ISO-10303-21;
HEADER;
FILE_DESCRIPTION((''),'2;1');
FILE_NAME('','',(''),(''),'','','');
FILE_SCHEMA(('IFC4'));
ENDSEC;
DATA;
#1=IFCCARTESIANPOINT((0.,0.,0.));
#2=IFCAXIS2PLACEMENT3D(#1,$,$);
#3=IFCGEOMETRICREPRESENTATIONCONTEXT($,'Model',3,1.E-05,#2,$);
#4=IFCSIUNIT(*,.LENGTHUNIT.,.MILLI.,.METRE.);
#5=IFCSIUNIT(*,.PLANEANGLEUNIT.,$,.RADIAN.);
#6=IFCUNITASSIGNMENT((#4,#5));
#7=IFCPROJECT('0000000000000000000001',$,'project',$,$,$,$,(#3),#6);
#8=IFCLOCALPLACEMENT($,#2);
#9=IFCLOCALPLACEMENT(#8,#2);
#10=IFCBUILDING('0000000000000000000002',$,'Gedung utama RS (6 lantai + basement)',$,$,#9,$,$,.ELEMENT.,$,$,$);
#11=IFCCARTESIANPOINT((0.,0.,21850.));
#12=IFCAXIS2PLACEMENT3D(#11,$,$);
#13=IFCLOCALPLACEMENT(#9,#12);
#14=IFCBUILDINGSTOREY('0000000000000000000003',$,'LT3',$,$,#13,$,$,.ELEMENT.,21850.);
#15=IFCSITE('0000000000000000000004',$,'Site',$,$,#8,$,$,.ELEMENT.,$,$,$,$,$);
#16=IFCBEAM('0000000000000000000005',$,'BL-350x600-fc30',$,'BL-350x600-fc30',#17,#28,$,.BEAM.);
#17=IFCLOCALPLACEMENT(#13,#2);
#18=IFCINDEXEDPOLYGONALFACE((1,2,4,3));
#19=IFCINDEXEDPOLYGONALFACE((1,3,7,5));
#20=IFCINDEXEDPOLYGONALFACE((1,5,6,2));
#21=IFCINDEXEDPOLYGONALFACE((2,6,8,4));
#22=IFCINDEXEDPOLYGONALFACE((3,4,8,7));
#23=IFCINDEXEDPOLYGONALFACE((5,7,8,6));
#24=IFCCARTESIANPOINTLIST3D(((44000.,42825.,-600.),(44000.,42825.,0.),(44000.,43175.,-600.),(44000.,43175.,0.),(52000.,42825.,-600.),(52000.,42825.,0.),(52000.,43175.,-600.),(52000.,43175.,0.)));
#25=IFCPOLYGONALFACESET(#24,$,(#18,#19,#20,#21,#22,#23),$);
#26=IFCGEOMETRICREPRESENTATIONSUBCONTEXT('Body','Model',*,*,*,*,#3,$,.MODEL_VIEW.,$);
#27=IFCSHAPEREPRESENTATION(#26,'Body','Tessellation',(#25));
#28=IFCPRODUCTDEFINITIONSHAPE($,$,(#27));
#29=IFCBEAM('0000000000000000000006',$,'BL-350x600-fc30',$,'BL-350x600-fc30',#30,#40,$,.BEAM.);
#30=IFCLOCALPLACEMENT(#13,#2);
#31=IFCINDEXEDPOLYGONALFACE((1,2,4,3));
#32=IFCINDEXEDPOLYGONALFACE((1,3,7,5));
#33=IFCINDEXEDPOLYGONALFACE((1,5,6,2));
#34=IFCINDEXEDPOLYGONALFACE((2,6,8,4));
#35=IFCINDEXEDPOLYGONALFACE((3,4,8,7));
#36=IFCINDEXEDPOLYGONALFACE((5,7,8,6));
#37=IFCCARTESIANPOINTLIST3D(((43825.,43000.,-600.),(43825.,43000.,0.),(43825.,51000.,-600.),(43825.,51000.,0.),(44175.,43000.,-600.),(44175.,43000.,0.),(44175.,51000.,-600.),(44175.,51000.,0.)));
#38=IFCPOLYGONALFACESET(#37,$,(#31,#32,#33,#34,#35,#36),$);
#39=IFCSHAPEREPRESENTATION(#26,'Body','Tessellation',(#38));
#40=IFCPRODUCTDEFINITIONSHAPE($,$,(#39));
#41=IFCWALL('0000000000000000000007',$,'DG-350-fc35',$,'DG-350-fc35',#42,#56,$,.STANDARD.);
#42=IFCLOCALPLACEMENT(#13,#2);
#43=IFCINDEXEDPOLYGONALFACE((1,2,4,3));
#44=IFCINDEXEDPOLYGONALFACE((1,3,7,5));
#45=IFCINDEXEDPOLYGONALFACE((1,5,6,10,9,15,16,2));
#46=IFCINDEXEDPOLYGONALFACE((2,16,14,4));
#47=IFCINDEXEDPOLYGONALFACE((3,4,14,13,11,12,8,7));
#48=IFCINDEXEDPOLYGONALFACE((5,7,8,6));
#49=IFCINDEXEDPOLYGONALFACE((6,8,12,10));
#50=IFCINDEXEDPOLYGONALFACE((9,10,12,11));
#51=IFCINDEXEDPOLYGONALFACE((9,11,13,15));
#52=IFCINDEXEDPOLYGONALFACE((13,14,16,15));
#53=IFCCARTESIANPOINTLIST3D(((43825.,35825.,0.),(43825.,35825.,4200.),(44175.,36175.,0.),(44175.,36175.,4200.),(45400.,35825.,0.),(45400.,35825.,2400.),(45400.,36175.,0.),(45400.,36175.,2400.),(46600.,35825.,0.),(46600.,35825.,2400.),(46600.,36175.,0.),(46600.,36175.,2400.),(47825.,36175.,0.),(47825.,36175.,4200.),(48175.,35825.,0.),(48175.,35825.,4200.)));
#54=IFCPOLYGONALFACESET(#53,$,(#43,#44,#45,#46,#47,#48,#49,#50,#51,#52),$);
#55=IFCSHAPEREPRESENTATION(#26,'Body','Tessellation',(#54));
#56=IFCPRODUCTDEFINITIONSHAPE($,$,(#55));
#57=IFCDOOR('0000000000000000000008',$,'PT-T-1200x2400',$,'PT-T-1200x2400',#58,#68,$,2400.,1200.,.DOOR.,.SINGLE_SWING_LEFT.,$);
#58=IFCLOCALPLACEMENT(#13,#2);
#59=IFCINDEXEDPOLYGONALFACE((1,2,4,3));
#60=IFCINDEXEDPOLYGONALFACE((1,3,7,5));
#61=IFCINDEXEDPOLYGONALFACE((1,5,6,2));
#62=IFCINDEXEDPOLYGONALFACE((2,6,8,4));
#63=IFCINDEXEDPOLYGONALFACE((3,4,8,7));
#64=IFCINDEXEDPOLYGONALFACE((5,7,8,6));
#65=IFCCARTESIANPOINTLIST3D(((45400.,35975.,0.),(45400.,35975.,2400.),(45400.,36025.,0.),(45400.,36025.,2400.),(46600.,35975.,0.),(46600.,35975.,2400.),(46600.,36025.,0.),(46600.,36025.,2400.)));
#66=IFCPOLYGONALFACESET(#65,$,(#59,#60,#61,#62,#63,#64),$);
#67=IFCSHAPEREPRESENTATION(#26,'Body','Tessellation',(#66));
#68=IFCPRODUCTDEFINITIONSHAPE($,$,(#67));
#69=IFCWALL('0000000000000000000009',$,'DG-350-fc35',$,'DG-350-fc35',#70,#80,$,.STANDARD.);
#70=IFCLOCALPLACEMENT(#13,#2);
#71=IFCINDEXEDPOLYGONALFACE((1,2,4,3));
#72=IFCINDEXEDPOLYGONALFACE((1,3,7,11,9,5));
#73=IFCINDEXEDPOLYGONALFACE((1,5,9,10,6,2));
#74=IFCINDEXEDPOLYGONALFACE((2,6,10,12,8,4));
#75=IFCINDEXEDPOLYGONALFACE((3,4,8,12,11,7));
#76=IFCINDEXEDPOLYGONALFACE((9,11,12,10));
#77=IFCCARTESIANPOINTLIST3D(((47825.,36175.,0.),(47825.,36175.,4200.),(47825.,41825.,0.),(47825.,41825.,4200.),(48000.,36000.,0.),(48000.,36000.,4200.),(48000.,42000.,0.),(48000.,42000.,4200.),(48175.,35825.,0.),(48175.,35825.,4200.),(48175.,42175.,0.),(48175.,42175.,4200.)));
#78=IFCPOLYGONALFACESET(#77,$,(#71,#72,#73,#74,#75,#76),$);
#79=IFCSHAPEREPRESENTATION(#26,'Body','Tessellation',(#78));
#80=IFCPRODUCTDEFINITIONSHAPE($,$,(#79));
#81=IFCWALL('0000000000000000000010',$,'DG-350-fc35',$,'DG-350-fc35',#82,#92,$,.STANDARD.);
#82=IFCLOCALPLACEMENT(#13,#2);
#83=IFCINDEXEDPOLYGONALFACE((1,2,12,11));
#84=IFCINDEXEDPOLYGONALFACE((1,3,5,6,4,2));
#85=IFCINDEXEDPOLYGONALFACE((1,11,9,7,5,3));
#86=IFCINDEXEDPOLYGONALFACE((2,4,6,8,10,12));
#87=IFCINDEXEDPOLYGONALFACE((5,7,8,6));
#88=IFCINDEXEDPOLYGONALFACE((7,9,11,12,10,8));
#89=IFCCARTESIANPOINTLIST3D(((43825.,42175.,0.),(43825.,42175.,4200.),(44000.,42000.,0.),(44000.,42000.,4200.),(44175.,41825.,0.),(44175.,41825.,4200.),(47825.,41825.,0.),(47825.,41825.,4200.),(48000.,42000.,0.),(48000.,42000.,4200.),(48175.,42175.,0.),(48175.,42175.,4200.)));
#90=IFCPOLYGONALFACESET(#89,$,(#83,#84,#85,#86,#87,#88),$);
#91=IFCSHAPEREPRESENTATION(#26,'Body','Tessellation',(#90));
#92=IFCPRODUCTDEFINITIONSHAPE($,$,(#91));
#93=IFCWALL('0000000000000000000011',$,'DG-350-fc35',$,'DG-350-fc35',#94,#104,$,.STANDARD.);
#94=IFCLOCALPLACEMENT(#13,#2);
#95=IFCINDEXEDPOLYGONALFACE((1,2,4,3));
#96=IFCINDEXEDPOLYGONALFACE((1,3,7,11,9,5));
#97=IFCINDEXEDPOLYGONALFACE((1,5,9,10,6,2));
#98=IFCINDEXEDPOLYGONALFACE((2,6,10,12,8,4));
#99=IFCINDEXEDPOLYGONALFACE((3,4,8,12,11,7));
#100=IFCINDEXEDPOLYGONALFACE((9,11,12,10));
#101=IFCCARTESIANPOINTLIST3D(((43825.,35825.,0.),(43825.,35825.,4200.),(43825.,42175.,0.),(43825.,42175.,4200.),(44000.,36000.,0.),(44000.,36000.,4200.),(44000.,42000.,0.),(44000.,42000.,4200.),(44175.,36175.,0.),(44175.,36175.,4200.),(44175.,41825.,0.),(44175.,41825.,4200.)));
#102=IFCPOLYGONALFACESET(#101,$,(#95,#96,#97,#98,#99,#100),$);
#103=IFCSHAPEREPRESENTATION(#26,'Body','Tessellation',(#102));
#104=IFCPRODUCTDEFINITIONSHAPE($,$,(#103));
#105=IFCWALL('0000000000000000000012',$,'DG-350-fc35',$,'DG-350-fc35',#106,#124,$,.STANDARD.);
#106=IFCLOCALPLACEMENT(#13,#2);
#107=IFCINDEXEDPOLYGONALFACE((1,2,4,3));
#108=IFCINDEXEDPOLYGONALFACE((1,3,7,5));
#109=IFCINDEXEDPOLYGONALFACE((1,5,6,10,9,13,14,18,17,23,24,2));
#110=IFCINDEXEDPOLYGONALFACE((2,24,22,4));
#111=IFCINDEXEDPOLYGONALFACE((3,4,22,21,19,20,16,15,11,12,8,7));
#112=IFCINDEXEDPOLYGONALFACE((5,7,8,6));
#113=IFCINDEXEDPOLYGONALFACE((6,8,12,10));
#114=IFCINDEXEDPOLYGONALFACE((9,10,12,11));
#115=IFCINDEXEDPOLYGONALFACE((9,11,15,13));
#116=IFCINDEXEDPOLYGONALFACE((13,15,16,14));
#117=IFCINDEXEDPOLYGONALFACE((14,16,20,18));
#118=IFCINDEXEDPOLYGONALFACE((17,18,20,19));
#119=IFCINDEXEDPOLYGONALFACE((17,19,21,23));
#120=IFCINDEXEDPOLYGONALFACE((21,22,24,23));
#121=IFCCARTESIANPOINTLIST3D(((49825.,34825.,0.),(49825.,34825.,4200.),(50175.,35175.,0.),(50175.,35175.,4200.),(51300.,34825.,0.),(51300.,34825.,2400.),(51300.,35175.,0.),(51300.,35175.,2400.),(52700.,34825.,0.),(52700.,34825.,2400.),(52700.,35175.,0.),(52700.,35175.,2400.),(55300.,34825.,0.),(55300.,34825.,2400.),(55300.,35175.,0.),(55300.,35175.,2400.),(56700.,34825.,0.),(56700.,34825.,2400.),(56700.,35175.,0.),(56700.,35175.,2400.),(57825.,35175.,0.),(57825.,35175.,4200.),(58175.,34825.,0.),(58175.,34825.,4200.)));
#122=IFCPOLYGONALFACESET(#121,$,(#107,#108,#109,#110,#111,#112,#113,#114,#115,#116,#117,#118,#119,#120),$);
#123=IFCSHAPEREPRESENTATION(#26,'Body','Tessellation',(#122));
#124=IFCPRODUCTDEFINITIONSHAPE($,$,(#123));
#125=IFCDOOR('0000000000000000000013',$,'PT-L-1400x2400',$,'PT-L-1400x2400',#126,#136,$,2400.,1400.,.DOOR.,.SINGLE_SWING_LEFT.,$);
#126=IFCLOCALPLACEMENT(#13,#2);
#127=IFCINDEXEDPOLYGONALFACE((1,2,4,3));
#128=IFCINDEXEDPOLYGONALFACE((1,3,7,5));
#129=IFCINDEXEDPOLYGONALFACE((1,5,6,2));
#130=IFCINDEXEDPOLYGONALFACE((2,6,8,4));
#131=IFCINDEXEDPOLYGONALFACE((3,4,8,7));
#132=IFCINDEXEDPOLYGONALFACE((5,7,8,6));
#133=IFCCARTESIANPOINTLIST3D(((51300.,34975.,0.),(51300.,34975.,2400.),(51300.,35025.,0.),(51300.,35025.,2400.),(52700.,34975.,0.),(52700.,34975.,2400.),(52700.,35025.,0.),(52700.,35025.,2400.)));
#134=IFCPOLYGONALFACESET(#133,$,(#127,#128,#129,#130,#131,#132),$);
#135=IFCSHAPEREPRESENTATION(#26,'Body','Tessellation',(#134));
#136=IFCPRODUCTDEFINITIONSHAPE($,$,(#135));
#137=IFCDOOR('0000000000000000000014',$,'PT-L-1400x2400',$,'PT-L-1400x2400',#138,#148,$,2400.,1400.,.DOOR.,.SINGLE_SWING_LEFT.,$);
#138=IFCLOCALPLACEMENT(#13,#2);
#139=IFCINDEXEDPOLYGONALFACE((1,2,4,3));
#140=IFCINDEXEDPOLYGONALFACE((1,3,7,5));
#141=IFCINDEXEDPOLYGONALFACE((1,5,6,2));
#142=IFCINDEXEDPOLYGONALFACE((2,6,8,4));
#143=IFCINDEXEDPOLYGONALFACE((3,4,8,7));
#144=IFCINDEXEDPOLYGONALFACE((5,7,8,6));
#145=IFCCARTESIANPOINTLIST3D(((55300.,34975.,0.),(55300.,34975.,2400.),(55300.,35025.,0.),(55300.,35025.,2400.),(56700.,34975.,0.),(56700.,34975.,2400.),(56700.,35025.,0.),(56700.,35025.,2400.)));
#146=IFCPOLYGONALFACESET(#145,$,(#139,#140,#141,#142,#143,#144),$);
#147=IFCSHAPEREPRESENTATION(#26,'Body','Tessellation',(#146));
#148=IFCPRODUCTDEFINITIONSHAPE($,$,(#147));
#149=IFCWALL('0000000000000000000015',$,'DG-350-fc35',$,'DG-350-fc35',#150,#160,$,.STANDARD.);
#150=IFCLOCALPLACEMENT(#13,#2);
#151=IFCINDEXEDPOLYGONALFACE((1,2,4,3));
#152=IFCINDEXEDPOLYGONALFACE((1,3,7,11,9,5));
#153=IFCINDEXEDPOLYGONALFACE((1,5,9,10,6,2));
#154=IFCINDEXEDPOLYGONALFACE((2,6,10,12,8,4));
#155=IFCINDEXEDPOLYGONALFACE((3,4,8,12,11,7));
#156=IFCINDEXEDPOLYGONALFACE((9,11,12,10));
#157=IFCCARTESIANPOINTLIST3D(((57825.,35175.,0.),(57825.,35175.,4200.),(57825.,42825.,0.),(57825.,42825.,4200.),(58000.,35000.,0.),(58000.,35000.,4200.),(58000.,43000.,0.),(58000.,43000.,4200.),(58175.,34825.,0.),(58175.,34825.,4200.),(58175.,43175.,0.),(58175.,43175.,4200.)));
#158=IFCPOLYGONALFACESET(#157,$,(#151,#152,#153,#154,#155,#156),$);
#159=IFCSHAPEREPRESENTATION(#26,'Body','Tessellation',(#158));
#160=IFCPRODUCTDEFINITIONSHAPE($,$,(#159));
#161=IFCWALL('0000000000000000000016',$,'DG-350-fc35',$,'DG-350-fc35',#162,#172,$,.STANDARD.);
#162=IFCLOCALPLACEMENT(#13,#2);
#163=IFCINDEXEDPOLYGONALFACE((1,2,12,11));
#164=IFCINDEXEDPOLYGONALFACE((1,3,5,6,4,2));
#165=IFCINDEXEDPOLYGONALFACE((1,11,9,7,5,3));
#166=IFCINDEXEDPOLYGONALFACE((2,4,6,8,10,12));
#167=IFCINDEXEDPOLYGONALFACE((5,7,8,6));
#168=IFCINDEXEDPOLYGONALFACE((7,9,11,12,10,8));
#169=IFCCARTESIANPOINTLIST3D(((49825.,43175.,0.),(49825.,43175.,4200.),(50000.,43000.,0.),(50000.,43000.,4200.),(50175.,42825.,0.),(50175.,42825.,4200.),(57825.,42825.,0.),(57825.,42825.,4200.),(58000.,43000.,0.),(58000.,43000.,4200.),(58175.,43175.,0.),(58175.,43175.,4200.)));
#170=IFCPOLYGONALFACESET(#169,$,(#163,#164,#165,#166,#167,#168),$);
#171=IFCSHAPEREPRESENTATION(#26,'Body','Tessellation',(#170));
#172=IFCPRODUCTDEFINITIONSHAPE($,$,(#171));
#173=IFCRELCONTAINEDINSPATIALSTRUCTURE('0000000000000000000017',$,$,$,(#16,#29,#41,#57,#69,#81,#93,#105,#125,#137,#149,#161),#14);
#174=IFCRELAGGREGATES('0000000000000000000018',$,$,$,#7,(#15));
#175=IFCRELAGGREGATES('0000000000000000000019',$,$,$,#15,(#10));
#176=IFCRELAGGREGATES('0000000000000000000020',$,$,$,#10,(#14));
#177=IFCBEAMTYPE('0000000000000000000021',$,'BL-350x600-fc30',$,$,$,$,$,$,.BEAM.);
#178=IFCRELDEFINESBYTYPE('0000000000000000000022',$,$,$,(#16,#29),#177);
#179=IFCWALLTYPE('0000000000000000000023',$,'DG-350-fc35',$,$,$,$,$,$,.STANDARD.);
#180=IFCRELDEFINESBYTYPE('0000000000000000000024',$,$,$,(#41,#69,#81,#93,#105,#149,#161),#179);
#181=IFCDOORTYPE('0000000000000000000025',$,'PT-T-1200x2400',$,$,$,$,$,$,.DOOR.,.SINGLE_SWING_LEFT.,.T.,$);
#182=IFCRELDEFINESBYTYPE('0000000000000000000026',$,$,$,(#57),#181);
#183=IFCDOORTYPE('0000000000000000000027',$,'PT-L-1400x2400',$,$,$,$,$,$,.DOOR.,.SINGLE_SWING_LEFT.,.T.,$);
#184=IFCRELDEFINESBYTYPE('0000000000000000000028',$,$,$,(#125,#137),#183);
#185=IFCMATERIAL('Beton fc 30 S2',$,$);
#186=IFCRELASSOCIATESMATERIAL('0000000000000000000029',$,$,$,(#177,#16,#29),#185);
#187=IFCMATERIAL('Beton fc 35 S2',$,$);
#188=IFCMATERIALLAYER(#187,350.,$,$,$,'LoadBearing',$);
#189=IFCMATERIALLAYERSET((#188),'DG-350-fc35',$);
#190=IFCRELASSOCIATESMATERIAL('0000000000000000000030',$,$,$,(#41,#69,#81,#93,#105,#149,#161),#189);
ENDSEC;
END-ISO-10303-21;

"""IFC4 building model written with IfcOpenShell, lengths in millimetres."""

from ifc_helpers import new_model, si_unit, frame, frame_2d, origin, origin_2d, place, context, subcontext, project, spatial, polyline, rectangle, outline, extrude, material, layer, layer_set, layer_usage, material_profile, profile_set, profile_usage, type_object, element, fill, save


model = new_model("IFC4")

# Units and contexts
model_context = context("Model", 3, precision=1e-05, world=origin())
body_context = subcontext(model_context, "Body", "Model", "MODEL_VIEW")
ifc_project = project(units=[si_unit("LENGTHUNIT", "METRE", prefix="MILLI"), si_unit("PLANEANGLEUNIT", "RADIAN")], contexts=[model_context])

# Site, building, storey
site_placement = place(None, origin())
site = spatial("IfcSite", under=ifc_project, at=site_placement, Name="Site", CompositionType="ELEMENT")
building_placement = place(site_placement, origin())
building = spatial("IfcBuilding", under=site, at=building_placement, Name="Gedung utama RS (6 lantai + basement)", CompositionType="ELEMENT")
storey_placement = place(building_placement, frame((0.0, 0.0, 21850.0)))
storey = spatial("IfcBuildingStorey", under=building, at=storey_placement, Name="LT3", CompositionType="ELEMENT", Elevation=21850.0)

# Beams
ifc_material_1 = material(Name="Beton fc 30 S2")
ifc_material_profile_1 = material_profile(ifc_material_1, rectangle(XDim=350.0, YDim=600.0, at=origin_2d()), Name="BL-350x600-fc30")
ifc_profile_set_1 = profile_set([ifc_material_profile_1], Name="BL-350x600-fc30")
ifc_profile_usage_1 = profile_usage(ifc_profile_set_1, cardinal=8)
beam_type = type_object("IfcBeamType", Name="BL-350x600-fc30", PredefinedType="BEAM", material=ifc_profile_set_1)
beam_1_placement = place(storey_placement, frame((44000.0, 43000.0, -300.0)))
element("IfcBeam", 1, at=beam_1_placement, inside=storey, type_object=beam_type, material=ifc_profile_usage_1, Name="BL-350x600-fc30", ObjectType="BL-350x600-fc30", PredefinedType="BEAM", context=body_context, shape_type="SweptSolid", body=[
    extrude(rectangle(XDim=350.0, YDim=600.0, at=origin_2d()), frame((0.0, 0.0, 0.0), z_axis=(1.0, 0.0, 0.0), x_axis=(0.0, 1.0, 0.0)), (0.0, 0.0, 1.0), 8000.0),
])
beam_2_placement = place(storey_placement, frame((44000.0, 43000.0, -300.0)))
element("IfcBeam", 2, at=beam_2_placement, inside=storey, type_object=beam_type, material=ifc_profile_usage_1, Name="BL-350x600-fc30", ObjectType="BL-350x600-fc30", PredefinedType="BEAM", context=body_context, shape_type="SweptSolid", body=[
    extrude(rectangle(XDim=350.0, YDim=600.0, at=origin_2d()), frame((0.0, 0.0, 0.0), z_axis=(0.0, 1.0, 0.0), x_axis=(-1.0, 0.0, 0.0)), (0.0, 0.0, 1.0), 8000.0),
])

# Wall, opening, door
ifc_material_2 = material(Name="Beton fc 35 S2")
ifc_layer = layer(ifc_material_2, 350.0, Category="LoadBearing")
ifc_layer_set = layer_set([ifc_layer], Name="DG-350-fc35")
ifc_layer_usage = layer_usage(ifc_layer_set, "AXIS2", "NEGATIVE", 175.0)
wall_type = type_object("IfcWallType", Name="DG-350-fc35", PredefinedType="STANDARD")
wall_1_placement = place(storey_placement, frame((44000.0, 36000.0, 0.0), z_axis=(0.0, 0.0, 1.0), x_axis=(1.0, 0.0, 0.0)))
wall_1 = element("IfcWall", 3, at=wall_1_placement, inside=storey, type_object=wall_type, material=ifc_layer_usage, Name="DG-350-fc35", ObjectType="DG-350-fc35", PredefinedType="STANDARD", context=body_context, shape_type="SweptSolid", body=[
    extrude(outline(polyline([(-175.0, -175.0), (0.0, 0.0), (175.0, 175.0), (3825.0, 175.0), (4000.0, 0.0), (4175.0, -175.0), (-175.0, -175.0)])), origin(), (0.0, 0.0, 1.0), 4200.0),
])
opening_1_placement = place(wall_1_placement, frame((1400.0, 0.0, 0.0), z_axis=(0.0, 0.0, 1.0), x_axis=(1.0, 0.0, 0.0)))
opening_1 = element("IfcOpeningElement", 4, at=opening_1_placement, cuts=wall_1, PredefinedType="OPENING", context=body_context, shape_type="SweptSolid", body=[
    extrude(rectangle(XDim=1200.0, YDim=370.0, at=frame_2d((600.0, 0.0))), origin(), (0.0, 0.0, 1.0), 2400.0),
])
door_type_1 = type_object("IfcDoorType", Name="PT-T-1200x2400", OperationType="SINGLE_SWING_LEFT", ParameterTakesPrecedence=True, PredefinedType="DOOR")
door_1_placement = place(opening_1_placement, origin())
door_1 = element("IfcDoor", 5, at=door_1_placement, inside=storey, type_object=door_type_1, Name="PT-T-1200x2400", ObjectType="PT-T-1200x2400", OperationType="SINGLE_SWING_LEFT", OverallHeight=2400.0, OverallWidth=1200.0, PredefinedType="DOOR", context=body_context, shape_type="SweptSolid", body=[
    extrude(rectangle(XDim=1200.0, YDim=50.0, at=frame_2d((600.0, 0.0))), origin(), (0.0, 0.0, 1.0), 2400.0),
])
fill(opening_1, door_1)

# Walls
wall_2_placement = place(storey_placement, frame((48000.0, 36000.0, 0.0), z_axis=(0.0, 0.0, 1.0), x_axis=(0.0, 1.0, 0.0)))
element("IfcWall", 6, at=wall_2_placement, inside=storey, type_object=wall_type, material=ifc_layer_usage, Name="DG-350-fc35", ObjectType="DG-350-fc35", PredefinedType="STANDARD", context=body_context, shape_type="SweptSolid", body=[
    extrude(outline(polyline([(-175.0, -175.0), (0.0, 0.0), (175.0, 175.0), (5825.0, 175.0), (6000.0, 0.0), (6175.0, -175.0), (-175.0, -175.0)])), origin(), (0.0, 0.0, 1.0), 4200.0),
])
wall_3_placement = place(storey_placement, frame((48000.0, 42000.0, 0.0), z_axis=(0.0, 0.0, 1.0), x_axis=(-1.0, 0.0, 0.0)))
element("IfcWall", 7, at=wall_3_placement, inside=storey, type_object=wall_type, material=ifc_layer_usage, Name="DG-350-fc35", ObjectType="DG-350-fc35", PredefinedType="STANDARD", context=body_context, shape_type="SweptSolid", body=[
    extrude(outline(polyline([(-175.0, -175.0), (0.0, 0.0), (175.0, 175.0), (3825.0, 175.0), (4000.0, 0.0), (4175.0, -175.0), (-175.0, -175.0)])), origin(), (0.0, 0.0, 1.0), 4200.0),
])
wall_4_placement = place(storey_placement, frame((44000.0, 42000.0, 0.0), z_axis=(0.0, 0.0, 1.0), x_axis=(0.0, -1.0, 0.0)))
element("IfcWall", 8, at=wall_4_placement, inside=storey, type_object=wall_type, material=ifc_layer_usage, Name="DG-350-fc35", ObjectType="DG-350-fc35", PredefinedType="STANDARD", context=body_context, shape_type="SweptSolid", body=[
    extrude(outline(polyline([(-175.0, -175.0), (0.0, 0.0), (175.0, 175.0), (5825.0, 175.0), (6000.0, 0.0), (6175.0, -175.0), (-175.0, -175.0)])), origin(), (0.0, 0.0, 1.0), 4200.0),
])

# Wall, openings, doors
wall_5_placement = place(storey_placement, frame((50000.0, 35000.0, 0.0), z_axis=(0.0, 0.0, 1.0), x_axis=(1.0, 0.0, 0.0)))
wall_5 = element("IfcWall", 9, at=wall_5_placement, inside=storey, type_object=wall_type, material=ifc_layer_usage, Name="DG-350-fc35", ObjectType="DG-350-fc35", PredefinedType="STANDARD", context=body_context, shape_type="SweptSolid", body=[
    extrude(outline(polyline([(-175.0, -175.0), (0.0, 0.0), (175.0, 175.0), (7825.0, 175.0), (8000.0, 0.0), (8175.0, -175.0), (-175.0, -175.0)])), origin(), (0.0, 0.0, 1.0), 4200.0),
])
opening_2_placement = place(wall_5_placement, frame((1300.0, 0.0, 0.0), z_axis=(0.0, 0.0, 1.0), x_axis=(1.0, 0.0, 0.0)))
opening_2 = element("IfcOpeningElement", 10, at=opening_2_placement, cuts=wall_5, PredefinedType="OPENING", context=body_context, shape_type="SweptSolid", body=[
    extrude(rectangle(XDim=1400.0, YDim=370.0, at=frame_2d((700.0, 0.0))), origin(), (0.0, 0.0, 1.0), 2400.0),
])
opening_3_placement = place(wall_5_placement, frame((5300.0, 0.0, 0.0), z_axis=(0.0, 0.0, 1.0), x_axis=(1.0, 0.0, 0.0)))
opening_3 = element("IfcOpeningElement", 11, at=opening_3_placement, cuts=wall_5, PredefinedType="OPENING", context=body_context, shape_type="SweptSolid", body=[
    extrude(rectangle(XDim=1400.0, YDim=370.0, at=frame_2d((700.0, 0.0))), origin(), (0.0, 0.0, 1.0), 2400.0),
])
door_type_2 = type_object("IfcDoorType", Name="PT-L-1400x2400", OperationType="SINGLE_SWING_LEFT", ParameterTakesPrecedence=True, PredefinedType="DOOR")
door_2_placement = place(opening_2_placement, origin())
door_2 = element("IfcDoor", 12, at=door_2_placement, inside=storey, type_object=door_type_2, Name="PT-L-1400x2400", ObjectType="PT-L-1400x2400", OperationType="SINGLE_SWING_LEFT", OverallHeight=2400.0, OverallWidth=1400.0, PredefinedType="DOOR", context=body_context, shape_type="SweptSolid", body=[
    extrude(rectangle(XDim=1400.0, YDim=50.0, at=frame_2d((700.0, 0.0))), origin(), (0.0, 0.0, 1.0), 2400.0),
])
fill(opening_2, door_2)
door_3_placement = place(opening_3_placement, origin())
door_3 = element("IfcDoor", 13, at=door_3_placement, inside=storey, type_object=door_type_2, Name="PT-L-1400x2400", ObjectType="PT-L-1400x2400", OperationType="SINGLE_SWING_LEFT", OverallHeight=2400.0, OverallWidth=1400.0, PredefinedType="DOOR", context=body_context, shape_type="SweptSolid", body=[
    extrude(rectangle(XDim=1400.0, YDim=50.0, at=frame_2d((700.0, 0.0))), origin(), (0.0, 0.0, 1.0), 2400.0),
])
fill(opening_3, door_3)

# Walls
for number, where, z_axis, x_axis, name in (
    (14, (58000.0, 35000.0, 0.0), (0.0, 0.0, 1.0), (0.0, 1.0, 0.0), "DG-350-fc35"),
    (15, (58000.0, 43000.0, 0.0), (0.0, 0.0, 1.0), (-1.0, 0.0, 0.0), "DG-350-fc35"),
):
    element("IfcWall", number, at=place(storey_placement, frame(where, z_axis=z_axis, x_axis=x_axis)), inside=storey, type_object=wall_type, material=ifc_layer_usage, Name=name, ObjectType="DG-350-fc35", PredefinedType="STANDARD", context=body_context, shape_type="SweptSolid", body=[
        extrude(outline(polyline([(-175.0, -175.0), (0.0, 0.0), (175.0, 175.0), (7825.0, 175.0), (8000.0, 0.0), (8175.0, -175.0), (-175.0, -175.0)])), origin(), (0.0, 0.0, 1.0), 4200.0),
    ])

save(model, "model.ifc")
